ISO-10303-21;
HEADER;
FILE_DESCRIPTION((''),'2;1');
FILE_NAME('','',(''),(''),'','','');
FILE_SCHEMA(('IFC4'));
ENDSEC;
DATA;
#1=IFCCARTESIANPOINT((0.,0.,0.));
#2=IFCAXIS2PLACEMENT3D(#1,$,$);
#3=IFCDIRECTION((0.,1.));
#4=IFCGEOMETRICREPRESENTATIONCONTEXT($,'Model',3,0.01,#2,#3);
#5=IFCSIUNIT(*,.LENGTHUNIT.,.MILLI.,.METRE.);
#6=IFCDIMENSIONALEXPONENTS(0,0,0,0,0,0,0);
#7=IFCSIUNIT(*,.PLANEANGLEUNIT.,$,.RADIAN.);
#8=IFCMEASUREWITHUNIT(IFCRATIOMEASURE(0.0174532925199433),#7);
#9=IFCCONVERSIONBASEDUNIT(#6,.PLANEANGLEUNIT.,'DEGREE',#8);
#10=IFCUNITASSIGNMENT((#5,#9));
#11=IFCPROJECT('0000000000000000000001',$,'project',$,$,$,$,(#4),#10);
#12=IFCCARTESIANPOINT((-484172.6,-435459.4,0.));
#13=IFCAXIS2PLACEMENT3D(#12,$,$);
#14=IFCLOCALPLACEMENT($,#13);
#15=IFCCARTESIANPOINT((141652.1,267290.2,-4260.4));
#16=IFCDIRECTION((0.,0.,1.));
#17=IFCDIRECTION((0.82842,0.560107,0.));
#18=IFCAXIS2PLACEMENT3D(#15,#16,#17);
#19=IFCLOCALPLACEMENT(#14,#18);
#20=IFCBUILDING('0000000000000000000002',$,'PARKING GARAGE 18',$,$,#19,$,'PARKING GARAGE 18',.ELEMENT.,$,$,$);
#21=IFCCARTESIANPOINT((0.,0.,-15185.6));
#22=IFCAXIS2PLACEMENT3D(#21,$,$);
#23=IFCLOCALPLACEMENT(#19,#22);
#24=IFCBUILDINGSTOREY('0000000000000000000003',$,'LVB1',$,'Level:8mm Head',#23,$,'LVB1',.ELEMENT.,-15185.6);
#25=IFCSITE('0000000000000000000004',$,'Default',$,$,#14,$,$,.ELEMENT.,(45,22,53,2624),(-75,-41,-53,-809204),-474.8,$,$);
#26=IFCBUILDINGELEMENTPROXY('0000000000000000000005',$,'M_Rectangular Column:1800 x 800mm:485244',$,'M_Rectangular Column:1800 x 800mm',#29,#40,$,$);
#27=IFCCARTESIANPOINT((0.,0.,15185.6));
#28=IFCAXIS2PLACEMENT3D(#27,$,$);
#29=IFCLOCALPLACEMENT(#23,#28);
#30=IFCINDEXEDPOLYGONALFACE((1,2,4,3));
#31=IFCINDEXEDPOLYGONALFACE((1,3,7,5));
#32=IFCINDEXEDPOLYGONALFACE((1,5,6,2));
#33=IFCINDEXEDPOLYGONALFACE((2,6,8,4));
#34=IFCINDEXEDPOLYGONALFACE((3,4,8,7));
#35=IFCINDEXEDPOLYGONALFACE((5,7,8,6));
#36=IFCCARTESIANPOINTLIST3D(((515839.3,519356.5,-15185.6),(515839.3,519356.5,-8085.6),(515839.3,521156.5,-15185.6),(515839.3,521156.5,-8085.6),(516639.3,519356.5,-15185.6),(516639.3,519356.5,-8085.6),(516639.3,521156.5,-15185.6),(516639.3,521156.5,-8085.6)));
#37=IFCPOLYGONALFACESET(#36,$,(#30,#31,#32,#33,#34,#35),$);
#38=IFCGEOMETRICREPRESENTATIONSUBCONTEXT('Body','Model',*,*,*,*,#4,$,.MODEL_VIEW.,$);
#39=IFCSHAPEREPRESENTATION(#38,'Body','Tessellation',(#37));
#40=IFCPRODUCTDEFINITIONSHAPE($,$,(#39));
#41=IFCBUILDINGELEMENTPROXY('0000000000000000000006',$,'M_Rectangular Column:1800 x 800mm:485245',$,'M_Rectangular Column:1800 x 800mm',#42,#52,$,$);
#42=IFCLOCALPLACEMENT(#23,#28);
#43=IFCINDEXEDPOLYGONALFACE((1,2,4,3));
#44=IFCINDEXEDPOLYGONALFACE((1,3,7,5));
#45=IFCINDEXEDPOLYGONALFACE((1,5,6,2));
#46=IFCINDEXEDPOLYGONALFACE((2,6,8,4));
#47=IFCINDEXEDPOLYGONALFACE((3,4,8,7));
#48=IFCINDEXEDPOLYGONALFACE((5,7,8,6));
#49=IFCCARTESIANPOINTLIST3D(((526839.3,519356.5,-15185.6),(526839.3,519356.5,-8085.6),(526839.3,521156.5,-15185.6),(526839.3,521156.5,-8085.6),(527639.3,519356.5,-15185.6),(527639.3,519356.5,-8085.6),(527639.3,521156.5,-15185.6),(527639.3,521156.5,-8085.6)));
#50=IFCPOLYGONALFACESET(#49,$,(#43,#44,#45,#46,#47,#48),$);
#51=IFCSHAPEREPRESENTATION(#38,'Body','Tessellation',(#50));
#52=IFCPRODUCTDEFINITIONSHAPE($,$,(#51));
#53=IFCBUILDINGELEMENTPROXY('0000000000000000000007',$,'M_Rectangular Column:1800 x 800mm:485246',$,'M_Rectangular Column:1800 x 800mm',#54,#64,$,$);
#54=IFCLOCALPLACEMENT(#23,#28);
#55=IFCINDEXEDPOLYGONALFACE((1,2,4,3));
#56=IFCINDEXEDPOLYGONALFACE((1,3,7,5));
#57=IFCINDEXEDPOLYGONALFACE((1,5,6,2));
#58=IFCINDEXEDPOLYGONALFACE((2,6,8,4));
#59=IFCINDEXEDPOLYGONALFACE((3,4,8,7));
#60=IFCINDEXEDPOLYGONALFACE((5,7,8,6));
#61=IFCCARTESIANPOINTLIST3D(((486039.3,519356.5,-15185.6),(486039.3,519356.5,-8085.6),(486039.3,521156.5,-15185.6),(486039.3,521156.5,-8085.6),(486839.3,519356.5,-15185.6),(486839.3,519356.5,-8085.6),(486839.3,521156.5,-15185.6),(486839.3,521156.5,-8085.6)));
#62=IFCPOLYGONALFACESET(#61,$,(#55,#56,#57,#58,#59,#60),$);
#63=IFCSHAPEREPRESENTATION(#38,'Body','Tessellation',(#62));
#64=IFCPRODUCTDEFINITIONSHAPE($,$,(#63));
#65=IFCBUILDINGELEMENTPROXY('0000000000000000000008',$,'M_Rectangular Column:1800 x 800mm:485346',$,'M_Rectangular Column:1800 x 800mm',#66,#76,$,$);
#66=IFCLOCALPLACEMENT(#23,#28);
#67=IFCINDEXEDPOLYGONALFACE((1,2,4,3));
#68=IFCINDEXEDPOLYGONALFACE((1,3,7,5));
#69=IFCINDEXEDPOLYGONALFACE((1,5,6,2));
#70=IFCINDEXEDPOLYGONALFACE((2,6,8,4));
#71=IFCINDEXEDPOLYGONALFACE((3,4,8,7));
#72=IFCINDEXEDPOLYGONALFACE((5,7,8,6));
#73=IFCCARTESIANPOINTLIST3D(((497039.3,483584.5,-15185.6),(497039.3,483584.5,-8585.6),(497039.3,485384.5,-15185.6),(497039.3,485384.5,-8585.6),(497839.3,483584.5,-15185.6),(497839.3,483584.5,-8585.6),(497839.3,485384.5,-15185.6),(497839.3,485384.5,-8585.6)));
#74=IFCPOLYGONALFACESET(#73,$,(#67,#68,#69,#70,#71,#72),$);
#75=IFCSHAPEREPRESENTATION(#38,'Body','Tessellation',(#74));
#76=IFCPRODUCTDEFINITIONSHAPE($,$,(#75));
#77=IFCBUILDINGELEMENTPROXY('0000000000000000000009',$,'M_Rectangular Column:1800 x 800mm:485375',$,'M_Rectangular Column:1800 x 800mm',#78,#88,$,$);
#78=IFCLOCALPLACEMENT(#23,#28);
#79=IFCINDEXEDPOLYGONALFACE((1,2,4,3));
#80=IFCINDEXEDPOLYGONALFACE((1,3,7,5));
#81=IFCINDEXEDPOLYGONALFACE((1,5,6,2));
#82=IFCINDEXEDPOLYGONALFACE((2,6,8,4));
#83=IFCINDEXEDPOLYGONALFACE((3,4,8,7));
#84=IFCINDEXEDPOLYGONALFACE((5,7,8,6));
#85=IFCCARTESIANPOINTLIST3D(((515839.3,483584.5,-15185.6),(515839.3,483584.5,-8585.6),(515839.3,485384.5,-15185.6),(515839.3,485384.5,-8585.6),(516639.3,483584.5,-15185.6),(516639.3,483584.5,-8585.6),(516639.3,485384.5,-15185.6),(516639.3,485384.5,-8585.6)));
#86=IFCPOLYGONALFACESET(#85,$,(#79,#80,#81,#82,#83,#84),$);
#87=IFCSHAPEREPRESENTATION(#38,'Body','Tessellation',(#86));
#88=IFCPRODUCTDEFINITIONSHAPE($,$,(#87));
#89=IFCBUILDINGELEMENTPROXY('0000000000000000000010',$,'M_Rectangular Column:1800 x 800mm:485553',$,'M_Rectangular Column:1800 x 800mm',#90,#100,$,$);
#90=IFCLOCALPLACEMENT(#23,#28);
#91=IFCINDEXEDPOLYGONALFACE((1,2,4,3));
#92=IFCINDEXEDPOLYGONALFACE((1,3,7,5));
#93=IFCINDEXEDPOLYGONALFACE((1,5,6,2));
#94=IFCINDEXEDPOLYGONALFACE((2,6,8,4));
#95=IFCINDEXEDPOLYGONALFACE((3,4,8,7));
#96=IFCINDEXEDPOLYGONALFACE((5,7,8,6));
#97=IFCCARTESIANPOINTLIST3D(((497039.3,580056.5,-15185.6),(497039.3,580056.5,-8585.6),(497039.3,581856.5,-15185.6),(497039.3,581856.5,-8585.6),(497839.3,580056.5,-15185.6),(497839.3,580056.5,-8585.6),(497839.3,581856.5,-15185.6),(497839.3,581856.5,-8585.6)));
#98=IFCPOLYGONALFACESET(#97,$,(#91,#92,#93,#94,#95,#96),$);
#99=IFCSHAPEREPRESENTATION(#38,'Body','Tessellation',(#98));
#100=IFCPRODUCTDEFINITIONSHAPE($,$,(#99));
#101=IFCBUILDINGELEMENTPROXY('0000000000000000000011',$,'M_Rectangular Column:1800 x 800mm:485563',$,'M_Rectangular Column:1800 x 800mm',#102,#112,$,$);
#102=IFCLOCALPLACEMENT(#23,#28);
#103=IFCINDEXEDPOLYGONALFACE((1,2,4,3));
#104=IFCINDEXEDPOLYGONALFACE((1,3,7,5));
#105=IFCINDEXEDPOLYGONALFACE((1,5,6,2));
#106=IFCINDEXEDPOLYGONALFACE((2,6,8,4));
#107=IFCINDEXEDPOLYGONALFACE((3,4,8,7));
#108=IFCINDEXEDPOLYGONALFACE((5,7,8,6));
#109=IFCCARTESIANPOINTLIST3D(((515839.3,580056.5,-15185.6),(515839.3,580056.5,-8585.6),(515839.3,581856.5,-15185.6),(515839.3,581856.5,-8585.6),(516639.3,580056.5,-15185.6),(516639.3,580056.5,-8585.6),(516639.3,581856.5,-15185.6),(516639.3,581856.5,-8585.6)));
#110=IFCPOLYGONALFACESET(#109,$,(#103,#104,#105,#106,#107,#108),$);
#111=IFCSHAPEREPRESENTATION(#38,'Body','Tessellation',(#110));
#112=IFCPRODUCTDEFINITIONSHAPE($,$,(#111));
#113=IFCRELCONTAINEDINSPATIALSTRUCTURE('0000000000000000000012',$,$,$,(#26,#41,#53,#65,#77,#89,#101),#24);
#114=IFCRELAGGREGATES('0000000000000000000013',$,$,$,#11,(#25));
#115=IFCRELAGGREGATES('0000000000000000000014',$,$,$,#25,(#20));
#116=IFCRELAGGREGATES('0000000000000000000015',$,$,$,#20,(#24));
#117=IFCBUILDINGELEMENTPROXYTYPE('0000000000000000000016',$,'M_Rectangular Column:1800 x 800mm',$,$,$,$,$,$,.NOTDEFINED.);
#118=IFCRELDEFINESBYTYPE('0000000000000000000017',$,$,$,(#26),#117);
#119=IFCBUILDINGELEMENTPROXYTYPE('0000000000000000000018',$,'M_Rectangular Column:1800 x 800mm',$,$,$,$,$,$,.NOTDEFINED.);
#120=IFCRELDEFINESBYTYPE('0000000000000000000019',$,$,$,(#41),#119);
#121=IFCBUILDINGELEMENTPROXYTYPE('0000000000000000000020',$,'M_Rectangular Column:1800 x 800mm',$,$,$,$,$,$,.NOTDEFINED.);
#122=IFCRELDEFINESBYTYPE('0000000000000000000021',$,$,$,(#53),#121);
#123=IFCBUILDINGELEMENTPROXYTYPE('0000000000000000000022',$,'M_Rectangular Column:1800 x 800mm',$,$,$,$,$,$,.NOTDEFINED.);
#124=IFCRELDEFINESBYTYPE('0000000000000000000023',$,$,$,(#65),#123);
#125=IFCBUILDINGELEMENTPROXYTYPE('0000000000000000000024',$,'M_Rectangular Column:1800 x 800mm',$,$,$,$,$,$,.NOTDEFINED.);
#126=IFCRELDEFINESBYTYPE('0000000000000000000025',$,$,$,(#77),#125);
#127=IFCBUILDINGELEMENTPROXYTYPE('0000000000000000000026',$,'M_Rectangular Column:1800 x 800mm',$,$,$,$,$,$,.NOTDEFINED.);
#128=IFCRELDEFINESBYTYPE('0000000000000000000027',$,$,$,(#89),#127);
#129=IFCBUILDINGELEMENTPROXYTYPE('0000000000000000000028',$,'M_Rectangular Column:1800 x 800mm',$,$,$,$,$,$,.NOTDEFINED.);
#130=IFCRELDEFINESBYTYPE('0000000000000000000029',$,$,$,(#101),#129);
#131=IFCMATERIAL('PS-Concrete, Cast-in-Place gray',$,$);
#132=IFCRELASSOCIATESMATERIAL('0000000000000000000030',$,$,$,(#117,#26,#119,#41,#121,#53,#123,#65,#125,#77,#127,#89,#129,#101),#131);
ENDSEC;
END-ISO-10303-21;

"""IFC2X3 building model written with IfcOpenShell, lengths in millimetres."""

from ifc_helpers import new_model, entity, si_unit, converted_unit, direction, frame, frame_2d, origin, place, context, subcontext, project, spatial, rectangle, extrude, source, transform, mapped, material, type_object, type_shapes, element, save


model = new_model("IFC2X3")

# Units and contexts
model_context = context("Model", 3, precision=0.01, world=origin(), true_north=direction((0.0, 1.0)))
body_context = subcontext(model_context, "Body", "Model", "MODEL_VIEW")
ifc_project = project(units=[si_unit("LENGTHUNIT", "METRE", prefix="MILLI"), converted_unit("PLANEANGLEUNIT", "DEGREE", entity("IfcRatioMeasure", 0.0174532925199433), si_unit("PLANEANGLEUNIT", "RADIAN"), dimensions=[0, 0, 0, 0, 0, 0, 0])], contexts=[model_context])

# Site, building, storey
site_placement = place(None, frame((-484172.6, -435459.4, 0.0)))
site = spatial("IfcSite", under=ifc_project, at=site_placement, Name="Default", CompositionType="ELEMENT", RefLatitude=(45, 22, 53, 2624), RefLongitude=(-75, -41, -53, -809204), RefElevation=-474.8)
building_placement = place(site_placement, frame((141652.1, 267290.2, -4260.4), z_axis=(0.0, 0.0, 1.0), x_axis=(0.82842, 0.560107, 0.0)))
building = spatial("IfcBuilding", under=site, at=building_placement, Name="PARKING GARAGE 18", LongName="PARKING GARAGE 18", CompositionType="ELEMENT")
storey_placement = place(building_placement, frame((0.0, 0.0, -15185.6)))
storey = spatial("IfcBuildingStorey", under=building, at=storey_placement, Name="LVB1", ObjectType="Level:8mm Head", LongName="LVB1", CompositionType="ELEMENT", Elevation=-15185.6)

# Building element proxies
ifc_material = material(Name="PS-Concrete, Cast-in-Place gray")
building_element_proxy_type_1 = type_object("IfcBuildingElementProxyType", Name="M_Rectangular Column:1800 x 800mm", PredefinedType="NOTDEFINED", material=ifc_material)
shared_shape_1 = source(origin(), body_context, "Body", "SweptSolid", [
    extrude(rectangle(XDim=800.0, YDim=1800.0, at=frame_2d((0.0, 0.0), x_axis=(1.0, 0.0))), frame((516239.3, 520256.5, -15185.6), z_axis=(0.0, 0.0, 1.0), x_axis=(-1.0, 0.0, 0.0)), (0.0, 0.0, 1.0), 7100.0),
])
type_shapes(building_element_proxy_type_1, [shared_shape_1])
proxy_1_placement = place(storey_placement, frame((0.0, 0.0, 15185.6)))
element("IfcBuildingElementProxy", 1, at=proxy_1_placement, inside=storey, type_object=building_element_proxy_type_1, material=ifc_material, Name="M_Rectangular Column:1800 x 800mm:485244", ObjectType="M_Rectangular Column:1800 x 800mm", context=body_context, shape_type="MappedRepresentation", body=[
    mapped(shared_shape_1, transform((0.0, 0.0, 0.0), scale=1.0)),
])
building_element_proxy_type_2 = type_object("IfcBuildingElementProxyType", Name="M_Rectangular Column:1800 x 800mm", PredefinedType="NOTDEFINED", material=ifc_material)
shared_shape_2 = source(origin(), body_context, "Body", "SweptSolid", [
    extrude(rectangle(XDim=800.0, YDim=1800.0, at=frame_2d((0.0, 0.0), x_axis=(1.0, 0.0))), frame((527239.3, 520256.5, -15185.6), z_axis=(0.0, 0.0, 1.0), x_axis=(-1.0, 0.0, 0.0)), (0.0, 0.0, 1.0), 7100.0),
])
type_shapes(building_element_proxy_type_2, [shared_shape_2])
proxy_2_placement = place(storey_placement, frame((0.0, 0.0, 15185.6)))
element("IfcBuildingElementProxy", 2, at=proxy_2_placement, inside=storey, type_object=building_element_proxy_type_2, material=ifc_material, Name="M_Rectangular Column:1800 x 800mm:485245", ObjectType="M_Rectangular Column:1800 x 800mm", context=body_context, shape_type="MappedRepresentation", body=[
    mapped(shared_shape_2, transform((0.0, 0.0, 0.0), scale=1.0)),
])
building_element_proxy_type_3 = type_object("IfcBuildingElementProxyType", Name="M_Rectangular Column:1800 x 800mm", PredefinedType="NOTDEFINED", material=ifc_material)
shared_shape_3 = source(origin(), body_context, "Body", "SweptSolid", [
    extrude(rectangle(XDim=800.0, YDim=1800.0, at=frame_2d((0.0, 0.0), x_axis=(1.0, 0.0))), frame((486439.3, 520256.5, -15185.6), z_axis=(0.0, 0.0, 1.0), x_axis=(-1.0, 0.0, 0.0)), (0.0, 0.0, 1.0), 7100.0),
])
type_shapes(building_element_proxy_type_3, [shared_shape_3])
proxy_3_placement = place(storey_placement, frame((0.0, 0.0, 15185.6)))
element("IfcBuildingElementProxy", 3, at=proxy_3_placement, inside=storey, type_object=building_element_proxy_type_3, material=ifc_material, Name="M_Rectangular Column:1800 x 800mm:485246", ObjectType="M_Rectangular Column:1800 x 800mm", context=body_context, shape_type="MappedRepresentation", body=[
    mapped(shared_shape_3, transform((0.0, 0.0, 0.0), scale=1.0)),
])
building_element_proxy_type_4 = type_object("IfcBuildingElementProxyType", Name="M_Rectangular Column:1800 x 800mm", PredefinedType="NOTDEFINED", material=ifc_material)
shared_shape_4 = source(origin(), body_context, "Body", "SweptSolid", [
    extrude(rectangle(XDim=800.0, YDim=1800.0, at=frame_2d((0.0, 0.0), x_axis=(1.0, 0.0))), frame((497439.3, 484484.5, -15185.6), z_axis=(0.0, 0.0, 1.0), x_axis=(-1.0, 0.0, 0.0)), (0.0, 0.0, 1.0), 6600.0),
])
type_shapes(building_element_proxy_type_4, [shared_shape_4])
proxy_4_placement = place(storey_placement, frame((0.0, 0.0, 15185.6)))
element("IfcBuildingElementProxy", 4, at=proxy_4_placement, inside=storey, type_object=building_element_proxy_type_4, material=ifc_material, Name="M_Rectangular Column:1800 x 800mm:485346", ObjectType="M_Rectangular Column:1800 x 800mm", context=body_context, shape_type="MappedRepresentation", body=[
    mapped(shared_shape_4, transform((0.0, 0.0, 0.0), scale=1.0)),
])
building_element_proxy_type_5 = type_object("IfcBuildingElementProxyType", Name="M_Rectangular Column:1800 x 800mm", PredefinedType="NOTDEFINED", material=ifc_material)
shared_shape_5 = source(origin(), body_context, "Body", "SweptSolid", [
    extrude(rectangle(XDim=800.0, YDim=1800.0, at=frame_2d((0.0, 0.0), x_axis=(1.0, 0.0))), frame((516239.3, 484484.5, -15185.6), z_axis=(0.0, 0.0, 1.0), x_axis=(-1.0, 0.0, 0.0)), (0.0, 0.0, 1.0), 6600.0),
])
type_shapes(building_element_proxy_type_5, [shared_shape_5])
proxy_5_placement = place(storey_placement, frame((0.0, 0.0, 15185.6)))
element("IfcBuildingElementProxy", 5, at=proxy_5_placement, inside=storey, type_object=building_element_proxy_type_5, material=ifc_material, Name="M_Rectangular Column:1800 x 800mm:485375", ObjectType="M_Rectangular Column:1800 x 800mm", context=body_context, shape_type="MappedRepresentation", body=[
    mapped(shared_shape_5, transform((0.0, 0.0, 0.0), scale=1.0)),
])
building_element_proxy_type_6 = type_object("IfcBuildingElementProxyType", Name="M_Rectangular Column:1800 x 800mm", PredefinedType="NOTDEFINED", material=ifc_material)
shared_shape_6 = source(origin(), body_context, "Body", "SweptSolid", [
    extrude(rectangle(XDim=800.0, YDim=1800.0, at=frame_2d((0.0, 0.0), x_axis=(1.0, 0.0))), frame((497439.3, 580956.5, -15185.6), z_axis=(0.0, 0.0, 1.0), x_axis=(-1.0, 0.0, 0.0)), (0.0, 0.0, 1.0), 6600.0),
])
type_shapes(building_element_proxy_type_6, [shared_shape_6])
proxy_6_placement = place(storey_placement, frame((0.0, 0.0, 15185.6)))
element("IfcBuildingElementProxy", 6, at=proxy_6_placement, inside=storey, type_object=building_element_proxy_type_6, material=ifc_material, Name="M_Rectangular Column:1800 x 800mm:485553", ObjectType="M_Rectangular Column:1800 x 800mm", context=body_context, shape_type="MappedRepresentation", body=[
    mapped(shared_shape_6, transform((0.0, 0.0, 0.0), scale=1.0)),
])
building_element_proxy_type_7 = type_object("IfcBuildingElementProxyType", Name="M_Rectangular Column:1800 x 800mm", PredefinedType="NOTDEFINED", material=ifc_material)
shared_shape_7 = source(origin(), body_context, "Body", "SweptSolid", [
    extrude(rectangle(XDim=800.0, YDim=1800.0, at=frame_2d((0.0, 0.0), x_axis=(1.0, 0.0))), frame((516239.3, 580956.5, -15185.6), z_axis=(0.0, 0.0, 1.0), x_axis=(-1.0, 0.0, 0.0)), (0.0, 0.0, 1.0), 6600.0),
])
type_shapes(building_element_proxy_type_7, [shared_shape_7])
proxy_7_placement = place(storey_placement, frame((0.0, 0.0, 15185.6)))
element("IfcBuildingElementProxy", 7, at=proxy_7_placement, inside=storey, type_object=building_element_proxy_type_7, material=ifc_material, Name="M_Rectangular Column:1800 x 800mm:485563", ObjectType="M_Rectangular Column:1800 x 800mm", context=body_context, shape_type="MappedRepresentation", body=[
    mapped(shared_shape_7, transform((0.0, 0.0, 0.0), scale=1.0)),
])

save(model, "model.ifc")
